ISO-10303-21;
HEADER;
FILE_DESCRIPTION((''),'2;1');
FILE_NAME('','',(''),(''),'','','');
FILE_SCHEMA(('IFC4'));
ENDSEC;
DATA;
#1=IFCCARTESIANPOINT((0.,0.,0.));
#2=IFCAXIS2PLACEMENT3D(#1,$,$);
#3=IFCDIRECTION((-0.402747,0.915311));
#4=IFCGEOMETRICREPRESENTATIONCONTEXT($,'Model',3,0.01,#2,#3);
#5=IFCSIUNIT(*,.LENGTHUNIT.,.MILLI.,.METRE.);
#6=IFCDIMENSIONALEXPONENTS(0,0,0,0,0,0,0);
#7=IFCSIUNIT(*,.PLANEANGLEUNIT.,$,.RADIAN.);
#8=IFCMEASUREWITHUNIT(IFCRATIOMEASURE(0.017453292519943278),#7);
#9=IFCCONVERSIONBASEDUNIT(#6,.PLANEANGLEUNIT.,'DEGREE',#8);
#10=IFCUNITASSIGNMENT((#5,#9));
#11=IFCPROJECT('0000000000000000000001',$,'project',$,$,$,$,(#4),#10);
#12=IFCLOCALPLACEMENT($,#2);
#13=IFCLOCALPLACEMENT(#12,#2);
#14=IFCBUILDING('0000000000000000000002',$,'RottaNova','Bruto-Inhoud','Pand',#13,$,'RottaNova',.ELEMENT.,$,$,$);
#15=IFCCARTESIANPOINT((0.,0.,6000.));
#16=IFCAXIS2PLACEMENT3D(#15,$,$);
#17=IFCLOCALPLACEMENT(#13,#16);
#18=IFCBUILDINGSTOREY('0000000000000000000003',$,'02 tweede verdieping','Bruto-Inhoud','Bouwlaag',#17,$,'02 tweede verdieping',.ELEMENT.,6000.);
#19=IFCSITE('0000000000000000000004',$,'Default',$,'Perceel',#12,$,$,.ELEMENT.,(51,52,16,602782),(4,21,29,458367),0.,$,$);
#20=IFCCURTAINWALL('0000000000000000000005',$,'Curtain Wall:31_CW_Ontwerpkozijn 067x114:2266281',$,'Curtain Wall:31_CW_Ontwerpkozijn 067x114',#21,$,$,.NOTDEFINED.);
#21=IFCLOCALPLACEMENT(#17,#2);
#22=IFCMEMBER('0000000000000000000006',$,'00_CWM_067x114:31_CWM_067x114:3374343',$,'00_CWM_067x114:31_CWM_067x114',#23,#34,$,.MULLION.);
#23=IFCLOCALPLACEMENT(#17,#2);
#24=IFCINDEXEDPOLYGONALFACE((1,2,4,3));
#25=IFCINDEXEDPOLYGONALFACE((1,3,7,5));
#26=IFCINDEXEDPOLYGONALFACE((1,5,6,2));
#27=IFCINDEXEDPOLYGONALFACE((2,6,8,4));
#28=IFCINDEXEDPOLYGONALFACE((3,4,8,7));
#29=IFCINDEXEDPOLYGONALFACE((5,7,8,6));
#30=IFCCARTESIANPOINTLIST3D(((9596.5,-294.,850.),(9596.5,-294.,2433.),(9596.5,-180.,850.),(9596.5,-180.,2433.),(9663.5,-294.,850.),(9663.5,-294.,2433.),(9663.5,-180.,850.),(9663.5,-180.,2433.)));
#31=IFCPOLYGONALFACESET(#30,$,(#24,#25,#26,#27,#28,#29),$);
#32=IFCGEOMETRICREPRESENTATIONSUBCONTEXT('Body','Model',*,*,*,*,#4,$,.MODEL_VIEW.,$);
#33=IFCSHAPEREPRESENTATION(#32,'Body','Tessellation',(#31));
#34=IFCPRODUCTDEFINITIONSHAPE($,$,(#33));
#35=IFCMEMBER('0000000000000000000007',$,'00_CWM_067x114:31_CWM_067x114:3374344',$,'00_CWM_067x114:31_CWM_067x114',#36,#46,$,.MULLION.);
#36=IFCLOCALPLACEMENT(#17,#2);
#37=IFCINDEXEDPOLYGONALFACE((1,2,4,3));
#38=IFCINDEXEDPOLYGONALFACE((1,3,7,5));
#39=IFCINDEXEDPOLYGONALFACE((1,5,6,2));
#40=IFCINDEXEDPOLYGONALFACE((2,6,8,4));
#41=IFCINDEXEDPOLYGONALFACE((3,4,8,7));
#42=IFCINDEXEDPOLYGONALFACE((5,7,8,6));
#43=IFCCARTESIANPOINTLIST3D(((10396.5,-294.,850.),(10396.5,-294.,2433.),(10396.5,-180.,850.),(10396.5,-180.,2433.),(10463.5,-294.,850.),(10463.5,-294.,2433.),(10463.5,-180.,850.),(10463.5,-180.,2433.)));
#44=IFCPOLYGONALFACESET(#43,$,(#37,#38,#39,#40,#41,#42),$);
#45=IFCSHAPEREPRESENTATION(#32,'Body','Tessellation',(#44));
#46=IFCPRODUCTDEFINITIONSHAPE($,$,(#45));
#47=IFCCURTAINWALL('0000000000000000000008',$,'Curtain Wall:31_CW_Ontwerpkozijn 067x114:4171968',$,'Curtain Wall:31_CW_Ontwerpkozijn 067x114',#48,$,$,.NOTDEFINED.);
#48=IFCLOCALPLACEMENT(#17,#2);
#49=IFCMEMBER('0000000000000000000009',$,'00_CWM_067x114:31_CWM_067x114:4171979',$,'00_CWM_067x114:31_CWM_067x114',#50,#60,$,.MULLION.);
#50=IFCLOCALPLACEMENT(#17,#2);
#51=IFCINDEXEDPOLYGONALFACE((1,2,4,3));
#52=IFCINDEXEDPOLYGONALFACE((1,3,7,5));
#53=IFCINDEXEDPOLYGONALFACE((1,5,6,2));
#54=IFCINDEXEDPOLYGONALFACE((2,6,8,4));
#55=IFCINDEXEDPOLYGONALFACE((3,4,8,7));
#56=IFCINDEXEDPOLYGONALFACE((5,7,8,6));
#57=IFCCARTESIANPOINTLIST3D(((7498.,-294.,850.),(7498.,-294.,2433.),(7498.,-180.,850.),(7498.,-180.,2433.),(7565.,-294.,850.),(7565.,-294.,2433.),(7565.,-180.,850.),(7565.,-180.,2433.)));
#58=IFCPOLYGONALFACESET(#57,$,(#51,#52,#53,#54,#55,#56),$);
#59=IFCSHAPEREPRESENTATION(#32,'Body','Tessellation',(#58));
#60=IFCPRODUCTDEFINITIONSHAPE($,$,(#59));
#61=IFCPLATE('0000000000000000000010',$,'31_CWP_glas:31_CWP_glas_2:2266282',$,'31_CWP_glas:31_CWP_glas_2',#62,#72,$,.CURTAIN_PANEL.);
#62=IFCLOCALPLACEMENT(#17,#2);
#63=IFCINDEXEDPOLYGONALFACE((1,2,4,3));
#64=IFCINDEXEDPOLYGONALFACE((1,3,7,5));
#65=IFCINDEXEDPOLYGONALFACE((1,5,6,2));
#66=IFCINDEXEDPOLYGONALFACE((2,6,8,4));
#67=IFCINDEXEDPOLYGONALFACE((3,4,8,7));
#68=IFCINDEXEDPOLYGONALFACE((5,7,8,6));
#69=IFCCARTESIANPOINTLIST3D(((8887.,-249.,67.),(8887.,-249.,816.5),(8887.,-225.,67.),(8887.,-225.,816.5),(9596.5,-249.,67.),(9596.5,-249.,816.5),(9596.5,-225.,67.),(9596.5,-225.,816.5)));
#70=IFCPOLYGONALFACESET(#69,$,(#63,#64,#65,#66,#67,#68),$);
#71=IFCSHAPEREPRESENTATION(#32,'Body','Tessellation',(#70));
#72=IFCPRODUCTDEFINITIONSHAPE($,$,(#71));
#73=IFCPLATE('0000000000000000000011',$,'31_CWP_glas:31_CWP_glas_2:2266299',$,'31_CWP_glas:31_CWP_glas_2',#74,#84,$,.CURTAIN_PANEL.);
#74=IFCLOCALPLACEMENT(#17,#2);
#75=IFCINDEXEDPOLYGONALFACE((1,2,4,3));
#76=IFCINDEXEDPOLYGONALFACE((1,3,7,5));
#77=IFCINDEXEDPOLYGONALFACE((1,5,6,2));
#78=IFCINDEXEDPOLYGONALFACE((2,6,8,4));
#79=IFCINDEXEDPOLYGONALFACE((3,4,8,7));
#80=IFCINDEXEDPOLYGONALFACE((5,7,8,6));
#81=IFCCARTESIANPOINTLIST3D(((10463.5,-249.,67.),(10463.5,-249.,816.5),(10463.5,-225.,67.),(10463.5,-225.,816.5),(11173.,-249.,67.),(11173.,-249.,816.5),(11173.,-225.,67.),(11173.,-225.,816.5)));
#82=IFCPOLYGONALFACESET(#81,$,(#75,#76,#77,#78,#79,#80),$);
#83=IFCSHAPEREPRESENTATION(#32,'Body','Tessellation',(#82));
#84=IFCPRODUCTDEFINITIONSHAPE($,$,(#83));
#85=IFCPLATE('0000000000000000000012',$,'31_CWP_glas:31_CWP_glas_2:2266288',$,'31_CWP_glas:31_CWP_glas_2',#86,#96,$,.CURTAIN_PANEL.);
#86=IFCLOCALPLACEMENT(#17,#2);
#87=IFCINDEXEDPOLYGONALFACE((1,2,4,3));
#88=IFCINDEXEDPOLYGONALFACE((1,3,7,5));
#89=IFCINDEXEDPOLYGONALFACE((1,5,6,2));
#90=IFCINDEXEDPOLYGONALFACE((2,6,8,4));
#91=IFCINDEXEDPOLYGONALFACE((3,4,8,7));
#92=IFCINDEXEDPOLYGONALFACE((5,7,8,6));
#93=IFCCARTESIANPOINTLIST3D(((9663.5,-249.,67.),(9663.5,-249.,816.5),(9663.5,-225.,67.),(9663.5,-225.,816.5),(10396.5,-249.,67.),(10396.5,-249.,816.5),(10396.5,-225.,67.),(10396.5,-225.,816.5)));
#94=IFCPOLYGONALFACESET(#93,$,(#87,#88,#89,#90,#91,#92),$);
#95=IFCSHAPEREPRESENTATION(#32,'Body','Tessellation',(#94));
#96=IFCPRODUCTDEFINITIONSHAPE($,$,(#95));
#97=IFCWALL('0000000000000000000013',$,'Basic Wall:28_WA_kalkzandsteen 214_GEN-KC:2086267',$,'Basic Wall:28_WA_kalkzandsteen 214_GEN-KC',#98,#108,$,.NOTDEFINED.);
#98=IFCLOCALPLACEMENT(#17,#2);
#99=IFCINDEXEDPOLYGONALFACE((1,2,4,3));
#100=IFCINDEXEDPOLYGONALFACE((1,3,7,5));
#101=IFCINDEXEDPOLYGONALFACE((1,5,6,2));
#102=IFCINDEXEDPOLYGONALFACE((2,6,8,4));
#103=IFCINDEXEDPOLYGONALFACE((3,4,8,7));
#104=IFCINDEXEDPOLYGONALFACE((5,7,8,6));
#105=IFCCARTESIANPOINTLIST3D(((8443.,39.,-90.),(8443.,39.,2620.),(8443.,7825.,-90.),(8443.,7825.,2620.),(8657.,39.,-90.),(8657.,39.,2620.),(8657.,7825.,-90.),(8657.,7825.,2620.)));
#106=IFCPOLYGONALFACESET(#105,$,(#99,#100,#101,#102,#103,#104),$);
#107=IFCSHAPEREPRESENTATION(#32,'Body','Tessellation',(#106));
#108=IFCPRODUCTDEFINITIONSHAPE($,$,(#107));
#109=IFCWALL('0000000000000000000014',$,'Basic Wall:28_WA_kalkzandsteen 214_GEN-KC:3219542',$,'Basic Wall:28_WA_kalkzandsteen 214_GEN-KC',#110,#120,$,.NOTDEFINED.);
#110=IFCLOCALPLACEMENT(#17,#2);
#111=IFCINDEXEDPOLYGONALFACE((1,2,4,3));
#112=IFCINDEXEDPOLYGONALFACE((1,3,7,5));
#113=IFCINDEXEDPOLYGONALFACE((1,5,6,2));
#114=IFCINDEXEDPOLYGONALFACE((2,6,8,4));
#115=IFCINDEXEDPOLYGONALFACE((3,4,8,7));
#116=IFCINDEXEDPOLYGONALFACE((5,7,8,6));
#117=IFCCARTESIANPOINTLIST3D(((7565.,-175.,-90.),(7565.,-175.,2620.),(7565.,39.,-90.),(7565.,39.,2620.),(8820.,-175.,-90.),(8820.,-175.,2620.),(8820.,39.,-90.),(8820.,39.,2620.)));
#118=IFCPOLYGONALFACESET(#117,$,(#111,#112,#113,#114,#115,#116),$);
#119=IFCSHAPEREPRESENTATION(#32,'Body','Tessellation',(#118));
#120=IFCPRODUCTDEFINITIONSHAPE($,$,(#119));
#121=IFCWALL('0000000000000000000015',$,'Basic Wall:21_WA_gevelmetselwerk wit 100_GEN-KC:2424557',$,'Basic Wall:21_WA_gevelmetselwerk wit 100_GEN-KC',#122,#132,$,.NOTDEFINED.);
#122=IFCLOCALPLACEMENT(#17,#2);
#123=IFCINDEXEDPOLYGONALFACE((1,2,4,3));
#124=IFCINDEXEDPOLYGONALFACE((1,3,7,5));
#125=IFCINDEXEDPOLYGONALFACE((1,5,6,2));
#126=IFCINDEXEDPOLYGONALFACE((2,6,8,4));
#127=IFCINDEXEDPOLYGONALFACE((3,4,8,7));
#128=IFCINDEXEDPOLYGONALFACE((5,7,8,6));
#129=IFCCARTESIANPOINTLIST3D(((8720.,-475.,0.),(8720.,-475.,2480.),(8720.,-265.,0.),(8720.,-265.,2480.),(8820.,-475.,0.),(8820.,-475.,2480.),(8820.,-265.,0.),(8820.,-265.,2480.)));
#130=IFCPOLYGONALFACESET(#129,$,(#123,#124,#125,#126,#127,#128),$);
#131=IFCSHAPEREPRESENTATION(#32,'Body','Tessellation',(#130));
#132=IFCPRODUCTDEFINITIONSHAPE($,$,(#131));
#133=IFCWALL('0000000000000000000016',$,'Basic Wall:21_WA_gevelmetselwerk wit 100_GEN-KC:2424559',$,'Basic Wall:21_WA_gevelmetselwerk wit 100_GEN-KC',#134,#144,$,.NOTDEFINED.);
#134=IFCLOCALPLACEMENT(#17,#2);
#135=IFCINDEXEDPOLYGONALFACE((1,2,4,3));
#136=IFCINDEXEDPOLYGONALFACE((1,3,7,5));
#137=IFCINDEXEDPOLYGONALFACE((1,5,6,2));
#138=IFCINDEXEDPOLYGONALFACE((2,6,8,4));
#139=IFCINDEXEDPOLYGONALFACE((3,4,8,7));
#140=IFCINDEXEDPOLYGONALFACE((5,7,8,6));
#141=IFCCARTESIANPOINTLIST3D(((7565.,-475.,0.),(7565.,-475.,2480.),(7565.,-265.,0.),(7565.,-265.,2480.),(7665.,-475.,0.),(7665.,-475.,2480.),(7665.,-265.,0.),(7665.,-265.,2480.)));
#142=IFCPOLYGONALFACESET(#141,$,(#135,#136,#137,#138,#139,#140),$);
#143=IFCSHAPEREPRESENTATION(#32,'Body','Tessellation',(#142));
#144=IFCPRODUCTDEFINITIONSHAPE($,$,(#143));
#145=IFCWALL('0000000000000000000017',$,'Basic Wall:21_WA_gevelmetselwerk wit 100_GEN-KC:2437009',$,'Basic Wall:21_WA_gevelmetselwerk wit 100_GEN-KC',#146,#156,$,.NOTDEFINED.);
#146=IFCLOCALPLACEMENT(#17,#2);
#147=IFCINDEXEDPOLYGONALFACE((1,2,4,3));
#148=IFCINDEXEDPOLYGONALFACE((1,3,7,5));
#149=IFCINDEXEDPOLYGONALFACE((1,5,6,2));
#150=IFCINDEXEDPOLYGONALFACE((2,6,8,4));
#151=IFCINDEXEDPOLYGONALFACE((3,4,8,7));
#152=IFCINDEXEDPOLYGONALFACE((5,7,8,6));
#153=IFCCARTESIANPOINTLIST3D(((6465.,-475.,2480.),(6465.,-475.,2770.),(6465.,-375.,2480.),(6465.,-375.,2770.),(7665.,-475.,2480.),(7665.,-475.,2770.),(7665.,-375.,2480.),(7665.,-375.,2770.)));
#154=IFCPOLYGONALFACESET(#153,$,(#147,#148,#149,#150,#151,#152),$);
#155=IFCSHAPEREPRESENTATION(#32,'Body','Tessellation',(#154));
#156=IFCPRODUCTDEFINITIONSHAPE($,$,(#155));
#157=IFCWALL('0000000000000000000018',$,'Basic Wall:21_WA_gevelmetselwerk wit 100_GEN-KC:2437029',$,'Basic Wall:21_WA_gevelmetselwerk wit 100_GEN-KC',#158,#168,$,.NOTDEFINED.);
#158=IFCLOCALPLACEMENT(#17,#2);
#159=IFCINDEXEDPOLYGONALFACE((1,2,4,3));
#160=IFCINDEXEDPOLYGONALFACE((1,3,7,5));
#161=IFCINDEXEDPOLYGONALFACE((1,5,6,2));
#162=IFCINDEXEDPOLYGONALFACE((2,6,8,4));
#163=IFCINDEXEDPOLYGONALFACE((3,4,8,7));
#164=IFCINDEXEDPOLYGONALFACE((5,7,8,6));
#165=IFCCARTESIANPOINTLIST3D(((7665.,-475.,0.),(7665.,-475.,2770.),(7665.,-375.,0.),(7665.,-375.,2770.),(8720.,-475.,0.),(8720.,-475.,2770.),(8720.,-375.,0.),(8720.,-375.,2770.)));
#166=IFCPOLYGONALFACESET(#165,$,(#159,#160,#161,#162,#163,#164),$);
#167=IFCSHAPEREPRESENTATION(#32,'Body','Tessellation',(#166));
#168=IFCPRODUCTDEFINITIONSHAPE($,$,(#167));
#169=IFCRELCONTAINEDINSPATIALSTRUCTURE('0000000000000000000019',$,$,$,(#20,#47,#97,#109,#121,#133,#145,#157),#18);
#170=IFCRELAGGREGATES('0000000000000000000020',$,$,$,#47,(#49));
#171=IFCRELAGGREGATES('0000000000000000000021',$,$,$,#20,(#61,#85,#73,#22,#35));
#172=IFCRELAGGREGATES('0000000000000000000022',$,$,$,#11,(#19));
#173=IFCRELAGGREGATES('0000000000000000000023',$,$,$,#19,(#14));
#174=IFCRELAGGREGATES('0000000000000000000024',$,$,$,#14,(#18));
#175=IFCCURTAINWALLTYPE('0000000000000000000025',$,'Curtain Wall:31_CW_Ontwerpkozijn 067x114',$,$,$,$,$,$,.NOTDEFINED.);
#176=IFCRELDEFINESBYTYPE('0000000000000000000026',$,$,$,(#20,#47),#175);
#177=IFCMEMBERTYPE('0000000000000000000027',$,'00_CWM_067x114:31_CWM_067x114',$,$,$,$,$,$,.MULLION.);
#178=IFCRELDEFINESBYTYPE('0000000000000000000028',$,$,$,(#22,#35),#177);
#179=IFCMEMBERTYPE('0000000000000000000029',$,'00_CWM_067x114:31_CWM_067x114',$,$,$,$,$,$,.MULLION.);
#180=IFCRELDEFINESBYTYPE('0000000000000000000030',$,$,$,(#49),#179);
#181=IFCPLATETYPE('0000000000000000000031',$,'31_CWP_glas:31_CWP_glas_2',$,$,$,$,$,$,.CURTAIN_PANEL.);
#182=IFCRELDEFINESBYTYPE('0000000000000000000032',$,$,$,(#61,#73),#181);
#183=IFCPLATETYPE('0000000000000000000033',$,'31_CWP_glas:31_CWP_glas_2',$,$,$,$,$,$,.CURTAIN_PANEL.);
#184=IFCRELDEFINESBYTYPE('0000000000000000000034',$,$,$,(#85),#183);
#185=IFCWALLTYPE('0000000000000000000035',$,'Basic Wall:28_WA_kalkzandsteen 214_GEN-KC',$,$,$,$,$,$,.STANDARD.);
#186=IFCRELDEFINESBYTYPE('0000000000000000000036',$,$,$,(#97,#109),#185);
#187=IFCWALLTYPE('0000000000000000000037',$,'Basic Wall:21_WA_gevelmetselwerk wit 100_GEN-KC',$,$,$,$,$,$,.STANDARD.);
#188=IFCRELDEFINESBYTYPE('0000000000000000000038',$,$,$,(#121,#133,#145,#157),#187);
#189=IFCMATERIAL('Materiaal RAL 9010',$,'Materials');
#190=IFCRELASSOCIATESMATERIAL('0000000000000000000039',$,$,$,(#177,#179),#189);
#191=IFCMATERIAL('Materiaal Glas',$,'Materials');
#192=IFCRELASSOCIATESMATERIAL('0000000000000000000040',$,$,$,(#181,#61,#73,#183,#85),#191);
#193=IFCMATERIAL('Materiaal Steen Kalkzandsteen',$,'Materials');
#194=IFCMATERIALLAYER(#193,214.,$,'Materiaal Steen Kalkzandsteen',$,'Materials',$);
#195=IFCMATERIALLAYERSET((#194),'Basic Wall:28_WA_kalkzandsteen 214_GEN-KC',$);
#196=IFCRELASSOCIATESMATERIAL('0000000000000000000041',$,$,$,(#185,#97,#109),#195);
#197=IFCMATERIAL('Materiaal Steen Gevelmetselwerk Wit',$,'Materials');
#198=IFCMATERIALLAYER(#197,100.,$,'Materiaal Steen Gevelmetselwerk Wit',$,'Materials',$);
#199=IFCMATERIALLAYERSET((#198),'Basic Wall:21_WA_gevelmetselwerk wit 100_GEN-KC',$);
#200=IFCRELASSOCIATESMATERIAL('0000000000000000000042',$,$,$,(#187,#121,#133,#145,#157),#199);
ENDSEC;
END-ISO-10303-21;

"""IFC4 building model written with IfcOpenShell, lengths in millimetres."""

from ifc_helpers import new_model, entity, si_unit, converted_unit, direction, frame, frame_2d, origin, origin_2d_with_axis, place, context, subcontext, project, spatial, rectangle, extrude, source, transform, mapped, material, layer, layer_set, material_profile, profile_set, type_object, type_shapes, element, aggregate, save


model = new_model("IFC4")

# Units and contexts
model_context = context("Model", 3, precision=0.01, world=origin(), true_north=direction((-0.402747, 0.915311)))
body_context = subcontext(model_context, "Body", "Model", "MODEL_VIEW")
ifc_project = project(units=[si_unit("LENGTHUNIT", "METRE", prefix="MILLI"), converted_unit("PLANEANGLEUNIT", "DEGREE", entity("IfcRatioMeasure", 0.017453292519943278), si_unit("PLANEANGLEUNIT", "RADIAN"), dimensions=[0, 0, 0, 0, 0, 0, 0])], contexts=[model_context])

# Site, building, storey
site_placement = place(None, origin())
site = spatial("IfcSite", under=ifc_project, at=site_placement, Name="Default", ObjectType="Perceel", CompositionType="ELEMENT", RefLatitude=(51, 52, 16, 602782), RefLongitude=(4, 21, 29, 458367), RefElevation=0.0)
building_placement = place(site_placement, origin())
building = spatial("IfcBuilding", under=site, at=building_placement, Name="RottaNova", Description="Bruto-Inhoud", ObjectType="Pand", LongName="RottaNova", CompositionType="ELEMENT")
storey_placement = place(building_placement, frame((0.0, 0.0, 6000.0)))
storey = spatial("IfcBuildingStorey", under=building, at=storey_placement, Name="02 tweede verdieping", Description="Bruto-Inhoud", ObjectType="Bouwlaag", LongName="02 tweede verdieping", CompositionType="ELEMENT", Elevation=6000.0)

# Curtain wall, members
curtain_wall_type = type_object("IfcCurtainWallType", Name="Curtain Wall:31_CW_Ontwerpkozijn 067x114", PredefinedType="NOTDEFINED")
curtain_wall_1_placement = place(storey_placement, frame((0.0, 0.0, -6000.0)))
curtain_wall_1 = element("IfcCurtainWall", 1, at=curtain_wall_1_placement, inside=storey, type_object=curtain_wall_type, Name="Curtain Wall:31_CW_Ontwerpkozijn 067x114:2266281", ObjectType="Curtain Wall:31_CW_Ontwerpkozijn 067x114", PredefinedType="NOTDEFINED")
ifc_material_1 = material(Name="Materiaal RAL 9010", Category="Materials")
ifc_material_profile = material_profile(ifc_material_1, rectangle(XDim=114.0, YDim=67.0, at=origin_2d_with_axis()), Name="31_CWM_067x114")
ifc_profile_set = profile_set([ifc_material_profile], Name="31_CWM_067x114")
member_type_1 = type_object("IfcMemberType", Name="00_CWM_067x114:31_CWM_067x114", PredefinedType="MULLION", material=ifc_profile_set)
shared_shape_1 = source(origin(), body_context, "Body", "SweptSolid", [
    extrude(rectangle(XDim=114.0, YDim=67.0, at=origin_2d_with_axis()), frame((0.0, 57.0, -1583.0), z_axis=(0.0, 0.0, 1.0), x_axis=(0.0, -1.0, 0.0)), (0.0, 0.0, 1.0), 1583.0),
])
type_shapes(member_type_1, [shared_shape_1])
member_1_placement = place(curtain_wall_1_placement, frame((9630.0, -180.0, 6850.0), z_axis=(0.0, 0.0, -1.0), x_axis=(1.0, 0.0, 0.0)))
member_1 = element("IfcMember", 2, at=member_1_placement, type_object=member_type_1, Name="00_CWM_067x114:31_CWM_067x114:3374343", ObjectType="00_CWM_067x114:31_CWM_067x114", PredefinedType="MULLION", context=body_context, shape_type="MappedRepresentation", body=[
    mapped(shared_shape_1, transform((0.0, 0.0, 0.0), scale=1.0)),
])
member_2_placement = place(curtain_wall_1_placement, frame((10430.0, -180.0, 6850.0), z_axis=(0.0, 0.0, -1.0), x_axis=(1.0, 0.0, 0.0)))
member_2 = element("IfcMember", 3, at=member_2_placement, type_object=member_type_1, Name="00_CWM_067x114:31_CWM_067x114:3374344", ObjectType="00_CWM_067x114:31_CWM_067x114", PredefinedType="MULLION", context=body_context, shape_type="MappedRepresentation", body=[
    mapped(shared_shape_1, transform((0.0, 0.0, 0.0), scale=1.0)),
])

# Curtain wall, member
curtain_wall_2_placement = place(storey_placement, frame((0.0, 0.0, -6000.0)))
curtain_wall_2 = element("IfcCurtainWall", 4, at=curtain_wall_2_placement, inside=storey, type_object=curtain_wall_type, Name="Curtain Wall:31_CW_Ontwerpkozijn 067x114:4171968", ObjectType="Curtain Wall:31_CW_Ontwerpkozijn 067x114", PredefinedType="NOTDEFINED")
member_type_2 = type_object("IfcMemberType", Name="00_CWM_067x114:31_CWM_067x114", PredefinedType="MULLION", material=ifc_profile_set)
shared_shape_2 = source(origin(), body_context, "Body", "SweptSolid", [
    extrude(rectangle(XDim=114.0, YDim=67.0, at=origin_2d_with_axis()), frame((-33.5, 57.0, -1583.0), z_axis=(0.0, 0.0, 1.0), x_axis=(0.0, -1.0, 0.0)), (0.0, 0.0, 1.0), 1583.0),
])
type_shapes(member_type_2, [shared_shape_2])
member_3_placement = place(curtain_wall_2_placement, frame((7565.0, -180.0, 6850.0), z_axis=(0.0, 0.0, -1.0), x_axis=(1.0, 0.0, 0.0)))
member_3 = element("IfcMember", 5, at=member_3_placement, type_object=member_type_2, Name="00_CWM_067x114:31_CWM_067x114:4171979", ObjectType="00_CWM_067x114:31_CWM_067x114", PredefinedType="MULLION", context=body_context, shape_type="MappedRepresentation", body=[
    mapped(shared_shape_2, transform((0.0, 0.0, 0.0), scale=1.0)),
])
aggregate(curtain_wall_2, [member_3])

# Plates
ifc_material_2 = material(Name="Materiaal Glas", Category="Materials")
plate_type_1 = type_object("IfcPlateType", Name="31_CWP_glas:31_CWP_glas_2", PredefinedType="CURTAIN_PANEL", material=ifc_material_2)
shared_shape_3 = source(origin(), body_context, "Body", "SweptSolid", [
    extrude(rectangle(XDim=24.0, YDim=709.5, at=frame_2d((0.0, 0.0), x_axis=(1.0, 0.0))), frame((354.8, 12.0, 0.0), z_axis=(0.0, 0.0, 1.0), x_axis=(0.0, 1.0, 0.0)), (0.0, 0.0, 1.0), 749.5),
])
type_shapes(plate_type_1, [shared_shape_3])
plate_1_placement = place(curtain_wall_1_placement, frame((8887.0, -249.0, 6067.0)))
plate_1 = element("IfcPlate", 6, at=plate_1_placement, type_object=plate_type_1, material=ifc_material_2, Name="31_CWP_glas:31_CWP_glas_2:2266282", ObjectType="31_CWP_glas:31_CWP_glas_2", PredefinedType="CURTAIN_PANEL", context=body_context, shape_type="MappedRepresentation", body=[
    mapped(shared_shape_3, transform((0.0, 0.0, 0.0), scale=1.0)),
])
plate_2_placement = place(curtain_wall_1_placement, frame((10463.5, -249.0, 6067.0)))
plate_2 = element("IfcPlate", 7, at=plate_2_placement, type_object=plate_type_1, material=ifc_material_2, Name="31_CWP_glas:31_CWP_glas_2:2266299", ObjectType="31_CWP_glas:31_CWP_glas_2", PredefinedType="CURTAIN_PANEL", context=body_context, shape_type="MappedRepresentation", body=[
    mapped(shared_shape_3, transform((0.0, 0.0, 0.0), scale=1.0)),
])
plate_type_2 = type_object("IfcPlateType", Name="31_CWP_glas:31_CWP_glas_2", PredefinedType="CURTAIN_PANEL", material=ifc_material_2)
shared_shape_4 = source(origin(), body_context, "Body", "SweptSolid", [
    extrude(rectangle(XDim=24.0, YDim=733.0, at=frame_2d((0.0, 0.0), x_axis=(1.0, 0.0))), frame((366.5, 12.0, 0.0), z_axis=(0.0, 0.0, 1.0), x_axis=(0.0, 1.0, 0.0)), (0.0, 0.0, 1.0), 749.5),
])
type_shapes(plate_type_2, [shared_shape_4])
plate_3_placement = place(curtain_wall_1_placement, frame((9663.5, -249.0, 6067.0)))
plate_3 = element("IfcPlate", 8, at=plate_3_placement, type_object=plate_type_2, material=ifc_material_2, Name="31_CWP_glas:31_CWP_glas_2:2266288", ObjectType="31_CWP_glas:31_CWP_glas_2", PredefinedType="CURTAIN_PANEL", context=body_context, shape_type="MappedRepresentation", body=[
    mapped(shared_shape_4, transform((0.0, 0.0, 0.0), scale=1.0)),
])

# Walls
ifc_material_3 = material(Name="Materiaal Steen Kalkzandsteen", Category="Materials")
ifc_layer_1 = layer(ifc_material_3, 214.0, Name="Materiaal Steen Kalkzandsteen", Category="Materials")
ifc_layer_set_1 = layer_set([ifc_layer_1], Name="Basic Wall:28_WA_kalkzandsteen 214_GEN-KC")
wall_type_1 = type_object("IfcWallType", Name="Basic Wall:28_WA_kalkzandsteen 214_GEN-KC", PredefinedType="STANDARD", material=ifc_layer_set_1)
wall_1_placement = place(storey_placement, frame((8550.0, 39.0, -90.0), z_axis=(0.0, 0.0, 1.0), x_axis=(0.0, 1.0, 0.0)))
element("IfcWall", 9, at=wall_1_placement, inside=storey, type_object=wall_type_1, material=ifc_layer_set_1, Name="Basic Wall:28_WA_kalkzandsteen 214_GEN-KC:2086267", ObjectType="Basic Wall:28_WA_kalkzandsteen 214_GEN-KC", PredefinedType="NOTDEFINED", context=body_context, shape_type="SweptSolid", body=[
    extrude(rectangle(XDim=7786.0, YDim=214.0, at=frame_2d((0.0, 0.0), x_axis=(1.0, 0.0))), frame((3893.0, 0.0, 0.0)), (0.0, 0.0, 1.0), 2710.0),
])
wall_2_placement = place(storey_placement, frame((8820.0, -68.0, -90.0), z_axis=(0.0, 0.0, 1.0), x_axis=(-1.0, 0.0, 0.0)))
element("IfcWall", 10, at=wall_2_placement, inside=storey, type_object=wall_type_1, material=ifc_layer_set_1, Name="Basic Wall:28_WA_kalkzandsteen 214_GEN-KC:3219542", ObjectType="Basic Wall:28_WA_kalkzandsteen 214_GEN-KC", PredefinedType="NOTDEFINED", context=body_context, shape_type="SweptSolid", body=[
    extrude(rectangle(XDim=1255.0, YDim=214.0, at=frame_2d((627.5, 0.0), x_axis=(-1.0, 0.0))), origin(), (0.0, 0.0, 1.0), 2710.0),
])
ifc_material_4 = material(Name="Materiaal Steen Gevelmetselwerk Wit", Category="Materials")
ifc_layer_2 = layer(ifc_material_4, 100.0, Name="Materiaal Steen Gevelmetselwerk Wit", Category="Materials")
ifc_layer_set_2 = layer_set([ifc_layer_2], Name="Basic Wall:21_WA_gevelmetselwerk wit 100_GEN-KC")
wall_type_2 = type_object("IfcWallType", Name="Basic Wall:21_WA_gevelmetselwerk wit 100_GEN-KC", PredefinedType="STANDARD", material=ifc_layer_set_2)
wall_3_placement = place(storey_placement, frame((8770.0, -265.0, 0.0), z_axis=(0.0, 0.0, 1.0), x_axis=(0.0, -1.0, 0.0)))
element("IfcWall", 11, at=wall_3_placement, inside=storey, type_object=wall_type_2, material=ifc_layer_set_2, Name="Basic Wall:21_WA_gevelmetselwerk wit 100_GEN-KC:2424557", ObjectType="Basic Wall:21_WA_gevelmetselwerk wit 100_GEN-KC", PredefinedType="NOTDEFINED", context=body_context, shape_type="SweptSolid", body=[
    extrude(rectangle(XDim=210.0, YDim=100.0, at=frame_2d((105.0, 0.0), x_axis=(-1.0, 0.0))), origin(), (0.0, 0.0, 1.0), 2480.0),
])
wall_4_placement = place(storey_placement, frame((7615.0, -265.0, 0.0), z_axis=(0.0, 0.0, 1.0), x_axis=(0.0, -1.0, 0.0)))
element("IfcWall", 12, at=wall_4_placement, inside=storey, type_object=wall_type_2, material=ifc_layer_set_2, Name="Basic Wall:21_WA_gevelmetselwerk wit 100_GEN-KC:2424559", ObjectType="Basic Wall:21_WA_gevelmetselwerk wit 100_GEN-KC", PredefinedType="NOTDEFINED", context=body_context, shape_type="SweptSolid", body=[
    extrude(rectangle(XDim=210.0, YDim=100.0, at=frame_2d((105.0, 0.0), x_axis=(-1.0, 0.0))), origin(), (0.0, 0.0, 1.0), 2480.0),
])
wall_5_placement = place(storey_placement, frame((7665.0, -425.0, 2480.0), z_axis=(0.0, 0.0, 1.0), x_axis=(-1.0, 0.0, 0.0)))
element("IfcWall", 13, at=wall_5_placement, inside=storey, type_object=wall_type_2, material=ifc_layer_set_2, Name="Basic Wall:21_WA_gevelmetselwerk wit 100_GEN-KC:2437009", ObjectType="Basic Wall:21_WA_gevelmetselwerk wit 100_GEN-KC", PredefinedType="NOTDEFINED", context=body_context, shape_type="SweptSolid", body=[
    extrude(rectangle(XDim=1200.0, YDim=100.0, at=frame_2d((600.0, 0.0), x_axis=(-1.0, 0.0))), origin(), (0.0, 0.0, 1.0), 290.0),
])
wall_6_placement = place(storey_placement, frame((8720.0, -425.0, 0.0), z_axis=(0.0, 0.0, 1.0), x_axis=(-1.0, 0.0, 0.0)))
element("IfcWall", 14, at=wall_6_placement, inside=storey, type_object=wall_type_2, material=ifc_layer_set_2, Name="Basic Wall:21_WA_gevelmetselwerk wit 100_GEN-KC:2437029", ObjectType="Basic Wall:21_WA_gevelmetselwerk wit 100_GEN-KC", PredefinedType="NOTDEFINED", context=body_context, shape_type="SweptSolid", body=[
    extrude(rectangle(XDim=1055.0, YDim=100.0, at=frame_2d((527.5, 0.0), x_axis=(-1.0, 0.0))), origin(), (0.0, 0.0, 1.0), 2770.0),
])

aggregate(curtain_wall_1, [plate_1, plate_3, plate_2, member_1, member_2])

save(model, "model.ifc")
